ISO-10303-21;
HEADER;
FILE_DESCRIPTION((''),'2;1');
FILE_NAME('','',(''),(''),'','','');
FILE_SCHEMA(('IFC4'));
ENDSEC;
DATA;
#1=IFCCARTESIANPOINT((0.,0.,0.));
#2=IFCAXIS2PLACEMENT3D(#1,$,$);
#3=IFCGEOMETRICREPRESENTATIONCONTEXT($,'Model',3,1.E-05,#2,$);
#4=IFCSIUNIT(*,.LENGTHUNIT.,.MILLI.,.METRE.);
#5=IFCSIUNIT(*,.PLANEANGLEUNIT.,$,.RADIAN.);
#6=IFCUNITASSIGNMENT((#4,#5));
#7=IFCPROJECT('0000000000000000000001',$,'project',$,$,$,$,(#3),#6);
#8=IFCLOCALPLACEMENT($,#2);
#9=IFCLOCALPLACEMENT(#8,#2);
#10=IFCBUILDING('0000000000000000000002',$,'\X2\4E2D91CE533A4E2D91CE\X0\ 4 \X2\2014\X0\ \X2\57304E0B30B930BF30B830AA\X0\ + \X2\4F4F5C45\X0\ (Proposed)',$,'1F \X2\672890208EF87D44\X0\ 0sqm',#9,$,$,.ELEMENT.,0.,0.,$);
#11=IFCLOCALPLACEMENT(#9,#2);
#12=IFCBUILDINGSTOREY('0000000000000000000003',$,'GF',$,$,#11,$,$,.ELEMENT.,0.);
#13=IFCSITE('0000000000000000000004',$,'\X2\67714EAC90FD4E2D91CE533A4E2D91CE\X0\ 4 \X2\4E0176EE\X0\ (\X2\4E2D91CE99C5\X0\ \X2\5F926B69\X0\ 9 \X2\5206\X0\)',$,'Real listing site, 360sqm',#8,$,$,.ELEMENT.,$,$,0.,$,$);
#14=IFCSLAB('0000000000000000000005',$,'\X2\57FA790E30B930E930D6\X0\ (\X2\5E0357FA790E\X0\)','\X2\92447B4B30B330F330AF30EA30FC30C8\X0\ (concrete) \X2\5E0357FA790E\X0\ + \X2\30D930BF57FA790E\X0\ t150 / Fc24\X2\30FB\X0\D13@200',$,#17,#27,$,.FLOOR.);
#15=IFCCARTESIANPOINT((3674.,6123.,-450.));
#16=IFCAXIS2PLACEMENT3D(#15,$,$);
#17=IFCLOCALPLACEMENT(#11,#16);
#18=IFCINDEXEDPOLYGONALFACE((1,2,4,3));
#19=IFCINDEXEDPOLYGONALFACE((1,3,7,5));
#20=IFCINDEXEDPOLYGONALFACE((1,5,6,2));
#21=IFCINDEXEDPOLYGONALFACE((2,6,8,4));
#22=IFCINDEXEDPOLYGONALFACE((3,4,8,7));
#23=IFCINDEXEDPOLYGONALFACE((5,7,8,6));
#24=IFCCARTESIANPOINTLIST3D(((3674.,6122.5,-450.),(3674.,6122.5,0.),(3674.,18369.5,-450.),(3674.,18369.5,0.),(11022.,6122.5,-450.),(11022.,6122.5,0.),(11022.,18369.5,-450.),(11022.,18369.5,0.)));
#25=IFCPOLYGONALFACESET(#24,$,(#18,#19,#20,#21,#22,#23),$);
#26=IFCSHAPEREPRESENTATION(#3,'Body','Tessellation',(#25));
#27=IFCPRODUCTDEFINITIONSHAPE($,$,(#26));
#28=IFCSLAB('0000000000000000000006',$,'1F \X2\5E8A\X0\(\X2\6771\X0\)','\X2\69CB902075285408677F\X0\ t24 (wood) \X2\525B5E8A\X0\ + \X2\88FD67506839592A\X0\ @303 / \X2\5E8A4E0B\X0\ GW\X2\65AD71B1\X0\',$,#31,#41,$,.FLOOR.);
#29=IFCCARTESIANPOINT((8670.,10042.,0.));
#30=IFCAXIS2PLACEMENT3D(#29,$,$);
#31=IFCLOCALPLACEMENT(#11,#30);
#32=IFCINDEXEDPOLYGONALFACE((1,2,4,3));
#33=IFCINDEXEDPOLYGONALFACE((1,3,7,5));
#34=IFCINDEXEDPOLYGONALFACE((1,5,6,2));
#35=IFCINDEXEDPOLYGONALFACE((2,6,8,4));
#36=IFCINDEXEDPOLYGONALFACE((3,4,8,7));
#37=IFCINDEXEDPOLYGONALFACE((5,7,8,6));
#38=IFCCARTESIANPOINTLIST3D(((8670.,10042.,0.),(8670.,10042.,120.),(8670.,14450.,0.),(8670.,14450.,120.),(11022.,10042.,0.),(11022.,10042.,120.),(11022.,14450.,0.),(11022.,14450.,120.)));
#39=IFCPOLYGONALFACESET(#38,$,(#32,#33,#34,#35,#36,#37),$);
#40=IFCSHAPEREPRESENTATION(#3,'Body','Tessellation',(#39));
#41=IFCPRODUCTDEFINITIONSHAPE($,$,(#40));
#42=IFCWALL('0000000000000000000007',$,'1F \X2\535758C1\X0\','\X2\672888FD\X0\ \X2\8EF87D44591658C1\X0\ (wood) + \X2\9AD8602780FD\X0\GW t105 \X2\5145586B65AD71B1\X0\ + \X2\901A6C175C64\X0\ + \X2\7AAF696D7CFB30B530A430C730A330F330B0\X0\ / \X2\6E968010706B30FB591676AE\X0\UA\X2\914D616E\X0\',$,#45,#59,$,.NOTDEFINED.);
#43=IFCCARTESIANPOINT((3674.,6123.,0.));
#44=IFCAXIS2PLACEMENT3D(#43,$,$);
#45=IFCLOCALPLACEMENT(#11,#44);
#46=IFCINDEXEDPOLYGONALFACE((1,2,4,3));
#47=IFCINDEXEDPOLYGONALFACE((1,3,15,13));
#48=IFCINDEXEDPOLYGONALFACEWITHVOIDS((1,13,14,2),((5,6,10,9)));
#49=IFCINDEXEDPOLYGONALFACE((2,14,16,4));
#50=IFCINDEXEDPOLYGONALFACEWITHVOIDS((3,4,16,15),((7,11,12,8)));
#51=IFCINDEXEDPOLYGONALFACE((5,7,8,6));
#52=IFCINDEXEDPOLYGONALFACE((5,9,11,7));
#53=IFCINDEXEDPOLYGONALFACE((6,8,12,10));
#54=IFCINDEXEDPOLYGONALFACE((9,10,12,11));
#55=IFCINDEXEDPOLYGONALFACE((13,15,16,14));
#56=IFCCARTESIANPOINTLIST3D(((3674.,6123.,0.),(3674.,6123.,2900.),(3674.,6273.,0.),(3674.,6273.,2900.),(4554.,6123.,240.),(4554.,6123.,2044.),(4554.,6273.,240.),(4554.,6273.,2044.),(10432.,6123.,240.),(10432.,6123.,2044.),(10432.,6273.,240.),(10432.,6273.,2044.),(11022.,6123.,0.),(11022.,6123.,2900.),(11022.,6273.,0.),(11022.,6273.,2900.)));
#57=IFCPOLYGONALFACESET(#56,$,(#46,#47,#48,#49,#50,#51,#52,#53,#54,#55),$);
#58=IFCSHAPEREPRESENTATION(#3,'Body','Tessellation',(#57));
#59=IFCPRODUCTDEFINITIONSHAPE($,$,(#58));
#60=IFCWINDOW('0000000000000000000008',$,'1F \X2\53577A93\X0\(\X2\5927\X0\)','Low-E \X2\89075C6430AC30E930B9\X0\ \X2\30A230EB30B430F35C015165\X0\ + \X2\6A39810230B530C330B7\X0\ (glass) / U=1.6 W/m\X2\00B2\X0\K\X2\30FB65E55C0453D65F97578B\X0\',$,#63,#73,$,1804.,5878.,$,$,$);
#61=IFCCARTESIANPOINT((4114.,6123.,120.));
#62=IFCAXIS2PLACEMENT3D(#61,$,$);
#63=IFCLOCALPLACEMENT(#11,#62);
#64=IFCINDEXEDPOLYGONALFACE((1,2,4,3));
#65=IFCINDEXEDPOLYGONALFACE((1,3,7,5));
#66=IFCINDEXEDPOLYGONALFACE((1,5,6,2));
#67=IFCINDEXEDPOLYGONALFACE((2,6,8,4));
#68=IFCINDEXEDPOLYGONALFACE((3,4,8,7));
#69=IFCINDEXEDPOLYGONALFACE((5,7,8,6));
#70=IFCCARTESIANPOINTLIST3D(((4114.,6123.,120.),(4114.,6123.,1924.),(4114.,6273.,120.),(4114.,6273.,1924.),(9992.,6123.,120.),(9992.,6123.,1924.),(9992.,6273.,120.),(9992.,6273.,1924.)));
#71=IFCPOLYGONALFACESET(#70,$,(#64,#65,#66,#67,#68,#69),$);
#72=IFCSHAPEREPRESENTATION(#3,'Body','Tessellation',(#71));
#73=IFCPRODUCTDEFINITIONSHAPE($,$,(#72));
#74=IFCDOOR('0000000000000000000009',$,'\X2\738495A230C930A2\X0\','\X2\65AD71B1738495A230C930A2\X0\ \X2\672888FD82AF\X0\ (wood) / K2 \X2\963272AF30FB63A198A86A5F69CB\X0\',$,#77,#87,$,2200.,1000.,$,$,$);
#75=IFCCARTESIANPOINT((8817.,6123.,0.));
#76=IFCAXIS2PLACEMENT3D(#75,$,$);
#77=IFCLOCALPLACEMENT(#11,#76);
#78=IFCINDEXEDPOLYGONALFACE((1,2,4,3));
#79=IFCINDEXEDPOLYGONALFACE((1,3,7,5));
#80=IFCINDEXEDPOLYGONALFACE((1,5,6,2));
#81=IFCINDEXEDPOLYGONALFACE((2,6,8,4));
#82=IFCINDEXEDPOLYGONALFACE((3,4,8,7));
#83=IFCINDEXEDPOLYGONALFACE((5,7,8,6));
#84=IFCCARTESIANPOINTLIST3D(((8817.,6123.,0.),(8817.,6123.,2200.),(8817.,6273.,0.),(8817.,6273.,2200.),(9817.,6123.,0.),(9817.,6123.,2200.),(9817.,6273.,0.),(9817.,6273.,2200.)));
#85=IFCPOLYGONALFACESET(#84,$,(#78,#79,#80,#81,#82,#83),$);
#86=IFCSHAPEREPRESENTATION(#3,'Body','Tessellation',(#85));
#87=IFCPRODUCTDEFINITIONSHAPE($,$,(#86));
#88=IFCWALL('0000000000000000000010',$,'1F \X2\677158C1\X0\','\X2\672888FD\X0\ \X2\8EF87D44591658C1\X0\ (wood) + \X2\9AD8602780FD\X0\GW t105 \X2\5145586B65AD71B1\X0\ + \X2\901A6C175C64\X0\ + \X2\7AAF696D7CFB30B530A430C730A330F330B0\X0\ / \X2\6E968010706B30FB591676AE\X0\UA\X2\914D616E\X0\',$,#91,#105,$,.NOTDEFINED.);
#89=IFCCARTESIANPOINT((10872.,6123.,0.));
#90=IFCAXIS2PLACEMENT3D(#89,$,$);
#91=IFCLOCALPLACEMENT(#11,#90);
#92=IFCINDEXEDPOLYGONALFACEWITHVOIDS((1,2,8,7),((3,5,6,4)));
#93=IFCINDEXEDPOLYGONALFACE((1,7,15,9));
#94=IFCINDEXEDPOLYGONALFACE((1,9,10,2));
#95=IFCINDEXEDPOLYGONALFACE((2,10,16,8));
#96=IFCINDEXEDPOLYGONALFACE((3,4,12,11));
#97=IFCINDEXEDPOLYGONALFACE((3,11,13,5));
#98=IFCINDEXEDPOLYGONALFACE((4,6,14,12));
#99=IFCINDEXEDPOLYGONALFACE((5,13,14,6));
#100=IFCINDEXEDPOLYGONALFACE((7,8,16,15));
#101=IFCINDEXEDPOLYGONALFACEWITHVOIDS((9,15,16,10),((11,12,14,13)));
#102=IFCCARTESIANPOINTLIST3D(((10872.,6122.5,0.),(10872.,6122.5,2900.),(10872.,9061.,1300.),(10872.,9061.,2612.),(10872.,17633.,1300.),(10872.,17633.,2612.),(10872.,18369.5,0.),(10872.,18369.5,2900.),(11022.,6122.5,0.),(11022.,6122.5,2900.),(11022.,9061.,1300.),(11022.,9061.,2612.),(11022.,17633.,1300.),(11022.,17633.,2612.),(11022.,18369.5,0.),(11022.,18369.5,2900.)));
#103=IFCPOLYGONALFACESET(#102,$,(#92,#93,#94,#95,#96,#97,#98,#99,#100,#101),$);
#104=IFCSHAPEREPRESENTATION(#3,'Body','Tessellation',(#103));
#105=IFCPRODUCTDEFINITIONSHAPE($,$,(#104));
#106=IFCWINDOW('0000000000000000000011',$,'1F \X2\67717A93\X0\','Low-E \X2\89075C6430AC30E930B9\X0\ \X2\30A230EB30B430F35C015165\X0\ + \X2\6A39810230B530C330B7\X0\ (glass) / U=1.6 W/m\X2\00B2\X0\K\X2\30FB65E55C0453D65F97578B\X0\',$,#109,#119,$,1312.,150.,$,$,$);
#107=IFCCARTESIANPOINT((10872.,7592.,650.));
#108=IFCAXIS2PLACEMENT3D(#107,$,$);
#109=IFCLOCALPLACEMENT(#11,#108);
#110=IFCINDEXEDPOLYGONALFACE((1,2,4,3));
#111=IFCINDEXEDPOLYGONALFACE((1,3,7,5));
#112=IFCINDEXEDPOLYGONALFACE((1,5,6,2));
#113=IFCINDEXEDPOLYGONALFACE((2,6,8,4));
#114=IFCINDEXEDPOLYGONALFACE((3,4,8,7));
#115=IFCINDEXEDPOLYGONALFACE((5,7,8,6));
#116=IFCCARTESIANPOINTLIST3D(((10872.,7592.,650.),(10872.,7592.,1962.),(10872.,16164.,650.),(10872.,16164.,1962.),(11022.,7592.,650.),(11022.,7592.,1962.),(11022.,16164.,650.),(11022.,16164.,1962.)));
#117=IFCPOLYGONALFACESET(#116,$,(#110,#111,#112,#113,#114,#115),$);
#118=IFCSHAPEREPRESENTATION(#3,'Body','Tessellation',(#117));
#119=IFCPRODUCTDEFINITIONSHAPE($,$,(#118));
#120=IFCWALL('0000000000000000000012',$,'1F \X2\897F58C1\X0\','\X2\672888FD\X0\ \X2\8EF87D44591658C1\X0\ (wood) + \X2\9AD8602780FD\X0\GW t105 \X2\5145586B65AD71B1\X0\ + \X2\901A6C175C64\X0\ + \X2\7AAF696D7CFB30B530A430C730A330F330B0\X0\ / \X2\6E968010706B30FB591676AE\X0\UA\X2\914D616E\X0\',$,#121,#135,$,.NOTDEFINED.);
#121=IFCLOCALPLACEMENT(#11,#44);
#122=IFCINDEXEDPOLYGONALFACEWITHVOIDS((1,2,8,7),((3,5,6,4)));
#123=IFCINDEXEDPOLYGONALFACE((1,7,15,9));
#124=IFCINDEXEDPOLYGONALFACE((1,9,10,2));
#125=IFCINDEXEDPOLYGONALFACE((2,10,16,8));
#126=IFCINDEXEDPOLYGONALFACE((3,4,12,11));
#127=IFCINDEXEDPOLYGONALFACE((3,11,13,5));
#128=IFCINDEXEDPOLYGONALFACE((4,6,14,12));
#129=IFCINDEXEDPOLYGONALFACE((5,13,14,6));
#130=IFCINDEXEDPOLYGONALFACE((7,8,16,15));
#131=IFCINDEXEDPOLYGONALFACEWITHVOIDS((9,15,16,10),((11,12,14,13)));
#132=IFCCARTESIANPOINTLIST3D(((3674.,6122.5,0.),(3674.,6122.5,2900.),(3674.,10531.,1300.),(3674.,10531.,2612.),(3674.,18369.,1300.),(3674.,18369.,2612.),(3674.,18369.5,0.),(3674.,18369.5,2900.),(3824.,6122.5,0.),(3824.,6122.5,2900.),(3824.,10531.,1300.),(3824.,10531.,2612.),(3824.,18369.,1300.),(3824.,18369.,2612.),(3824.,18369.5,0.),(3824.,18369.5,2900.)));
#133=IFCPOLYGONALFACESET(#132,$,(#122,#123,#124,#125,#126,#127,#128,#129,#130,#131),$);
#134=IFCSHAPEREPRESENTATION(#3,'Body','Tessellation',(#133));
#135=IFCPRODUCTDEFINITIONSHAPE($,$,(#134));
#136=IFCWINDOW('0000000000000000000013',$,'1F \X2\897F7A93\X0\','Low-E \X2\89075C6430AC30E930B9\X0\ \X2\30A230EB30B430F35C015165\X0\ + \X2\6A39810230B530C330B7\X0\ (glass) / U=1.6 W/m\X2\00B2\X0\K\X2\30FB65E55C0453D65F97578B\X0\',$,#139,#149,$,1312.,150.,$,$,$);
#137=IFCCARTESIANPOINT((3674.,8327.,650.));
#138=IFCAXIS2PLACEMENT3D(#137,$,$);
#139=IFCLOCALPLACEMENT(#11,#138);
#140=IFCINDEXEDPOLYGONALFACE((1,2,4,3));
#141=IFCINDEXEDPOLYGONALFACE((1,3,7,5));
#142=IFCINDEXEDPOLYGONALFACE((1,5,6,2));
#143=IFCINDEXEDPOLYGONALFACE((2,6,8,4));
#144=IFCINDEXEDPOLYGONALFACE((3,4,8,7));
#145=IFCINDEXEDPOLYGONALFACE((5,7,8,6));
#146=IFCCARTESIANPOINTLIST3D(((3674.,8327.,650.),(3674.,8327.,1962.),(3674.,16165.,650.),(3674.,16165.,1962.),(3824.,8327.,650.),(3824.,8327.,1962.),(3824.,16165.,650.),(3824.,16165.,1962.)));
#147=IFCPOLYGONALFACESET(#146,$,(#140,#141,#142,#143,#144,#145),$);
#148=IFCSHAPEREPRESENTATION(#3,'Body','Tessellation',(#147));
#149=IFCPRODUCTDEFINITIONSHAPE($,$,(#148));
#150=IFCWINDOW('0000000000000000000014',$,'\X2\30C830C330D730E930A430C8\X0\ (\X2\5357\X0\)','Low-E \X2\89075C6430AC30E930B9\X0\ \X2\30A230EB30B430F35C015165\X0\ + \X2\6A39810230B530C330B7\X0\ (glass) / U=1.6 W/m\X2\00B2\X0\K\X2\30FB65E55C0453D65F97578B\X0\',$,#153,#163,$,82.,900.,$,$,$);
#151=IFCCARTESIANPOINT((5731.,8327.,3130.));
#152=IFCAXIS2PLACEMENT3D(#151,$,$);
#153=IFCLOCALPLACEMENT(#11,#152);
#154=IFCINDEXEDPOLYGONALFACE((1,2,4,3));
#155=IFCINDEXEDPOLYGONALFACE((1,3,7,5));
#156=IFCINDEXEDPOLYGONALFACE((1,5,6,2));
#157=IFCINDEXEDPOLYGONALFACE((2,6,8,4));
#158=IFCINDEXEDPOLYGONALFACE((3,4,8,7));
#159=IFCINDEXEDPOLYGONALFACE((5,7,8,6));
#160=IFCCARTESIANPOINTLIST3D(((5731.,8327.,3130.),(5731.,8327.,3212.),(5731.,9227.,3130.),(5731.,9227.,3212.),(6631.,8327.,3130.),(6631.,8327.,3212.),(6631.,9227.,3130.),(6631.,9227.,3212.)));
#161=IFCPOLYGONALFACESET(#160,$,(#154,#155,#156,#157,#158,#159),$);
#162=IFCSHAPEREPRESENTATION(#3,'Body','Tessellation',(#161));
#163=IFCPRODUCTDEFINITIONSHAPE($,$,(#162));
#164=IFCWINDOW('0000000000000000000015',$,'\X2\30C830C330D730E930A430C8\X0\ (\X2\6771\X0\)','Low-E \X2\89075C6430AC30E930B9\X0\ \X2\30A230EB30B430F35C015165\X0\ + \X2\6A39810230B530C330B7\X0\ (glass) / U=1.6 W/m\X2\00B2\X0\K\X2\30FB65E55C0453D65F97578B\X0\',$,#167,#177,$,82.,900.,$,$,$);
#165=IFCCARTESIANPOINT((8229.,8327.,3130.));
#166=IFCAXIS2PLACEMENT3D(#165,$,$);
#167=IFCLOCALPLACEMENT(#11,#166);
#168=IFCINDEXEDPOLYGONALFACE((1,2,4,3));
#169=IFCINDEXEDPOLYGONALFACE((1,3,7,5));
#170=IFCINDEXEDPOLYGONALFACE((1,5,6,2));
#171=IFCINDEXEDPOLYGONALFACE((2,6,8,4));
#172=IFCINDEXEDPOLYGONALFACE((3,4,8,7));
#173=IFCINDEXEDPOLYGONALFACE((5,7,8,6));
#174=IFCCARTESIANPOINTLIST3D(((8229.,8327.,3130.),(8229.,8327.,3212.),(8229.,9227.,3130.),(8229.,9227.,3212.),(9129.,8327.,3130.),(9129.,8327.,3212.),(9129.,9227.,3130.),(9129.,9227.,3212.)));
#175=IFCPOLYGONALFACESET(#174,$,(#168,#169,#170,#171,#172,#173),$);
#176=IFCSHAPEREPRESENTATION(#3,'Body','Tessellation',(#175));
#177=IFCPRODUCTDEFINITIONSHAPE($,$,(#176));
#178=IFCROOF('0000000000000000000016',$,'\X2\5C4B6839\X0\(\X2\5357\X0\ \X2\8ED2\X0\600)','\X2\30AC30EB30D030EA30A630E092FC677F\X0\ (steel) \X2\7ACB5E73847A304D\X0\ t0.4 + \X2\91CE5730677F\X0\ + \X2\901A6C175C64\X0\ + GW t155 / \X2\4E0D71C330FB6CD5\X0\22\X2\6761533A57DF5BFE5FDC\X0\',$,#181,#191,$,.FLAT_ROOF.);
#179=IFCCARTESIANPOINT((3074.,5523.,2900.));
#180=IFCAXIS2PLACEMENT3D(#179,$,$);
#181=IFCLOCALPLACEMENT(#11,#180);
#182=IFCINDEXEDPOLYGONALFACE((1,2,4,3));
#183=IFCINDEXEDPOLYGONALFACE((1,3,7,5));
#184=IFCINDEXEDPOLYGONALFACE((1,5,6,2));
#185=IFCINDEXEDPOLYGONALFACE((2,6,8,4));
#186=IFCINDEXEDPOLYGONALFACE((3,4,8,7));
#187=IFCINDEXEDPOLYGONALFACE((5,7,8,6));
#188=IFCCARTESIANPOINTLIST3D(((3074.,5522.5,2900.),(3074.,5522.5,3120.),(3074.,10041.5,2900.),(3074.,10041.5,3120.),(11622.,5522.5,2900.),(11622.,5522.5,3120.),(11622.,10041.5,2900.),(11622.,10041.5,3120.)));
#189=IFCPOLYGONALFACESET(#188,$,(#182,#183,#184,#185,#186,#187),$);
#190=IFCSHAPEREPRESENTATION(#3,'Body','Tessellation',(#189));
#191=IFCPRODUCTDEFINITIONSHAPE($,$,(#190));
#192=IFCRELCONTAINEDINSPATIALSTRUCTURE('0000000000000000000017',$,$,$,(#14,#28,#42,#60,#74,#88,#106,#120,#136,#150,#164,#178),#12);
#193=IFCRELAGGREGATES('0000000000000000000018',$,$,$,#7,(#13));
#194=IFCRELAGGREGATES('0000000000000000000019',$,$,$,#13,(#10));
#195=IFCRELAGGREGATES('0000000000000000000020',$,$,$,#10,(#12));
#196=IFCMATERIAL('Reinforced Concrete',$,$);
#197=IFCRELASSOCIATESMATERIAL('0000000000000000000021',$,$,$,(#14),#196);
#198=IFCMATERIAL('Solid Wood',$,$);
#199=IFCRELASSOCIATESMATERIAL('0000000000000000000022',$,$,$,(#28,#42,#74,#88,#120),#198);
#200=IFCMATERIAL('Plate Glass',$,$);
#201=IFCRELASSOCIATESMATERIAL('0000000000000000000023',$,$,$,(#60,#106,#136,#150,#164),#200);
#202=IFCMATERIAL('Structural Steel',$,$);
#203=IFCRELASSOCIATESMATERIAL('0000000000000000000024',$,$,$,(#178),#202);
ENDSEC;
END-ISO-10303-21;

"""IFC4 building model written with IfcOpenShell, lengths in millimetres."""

from ifc_helpers import new_model, si_unit, frame, frame_2d, origin, place, context, project, spatial, rectangle, extrude, material, element, fill, save


model = new_model("IFC4")

# Units and contexts
model_context = context("Model", 3, precision=1e-05, world=origin())
ifc_project = project(units=[si_unit("LENGTHUNIT", "METRE", prefix="MILLI"), si_unit("PLANEANGLEUNIT", "RADIAN")], contexts=[model_context])

# Site, building, storey
site_placement = place(None, origin())
site = spatial("IfcSite", under=ifc_project, at=site_placement, Name="東京都中野区中野 4 丁目 (中野駅 徒歩 9 分)", ObjectType="Real listing site, 360sqm", CompositionType="ELEMENT", RefElevation=0.0)
building_placement = place(site_placement, origin())
building = spatial("IfcBuilding", under=site, at=building_placement, Name="中野区中野 4 — 地下スタジオ + 住居 (Proposed)", ObjectType="1F 木造軸組 0sqm", CompositionType="ELEMENT", ElevationOfRefHeight=0.0, ElevationOfTerrain=0.0)
storey_placement = place(building_placement, origin())
storey = spatial("IfcBuildingStorey", under=building, at=storey_placement, Name="GF", CompositionType="ELEMENT", Elevation=0.0)

# Slabs
ifc_material_1 = material(Name="Reinforced Concrete")
slab_1_placement = place(storey_placement, frame((3674.0, 6123.0, -450.0)))
element("IfcSlab", 1, at=slab_1_placement, inside=storey, material=ifc_material_1, Name="基礎スラブ (布基礎)", Description="鉄筋コンクリート (concrete) 布基礎 + ベタ基礎 t150 / Fc24・D13@200", PredefinedType="FLOOR", context=model_context, shape_type="SweptSolid", body=[
    extrude(rectangle(XDim=7348.0, YDim=12247.0, at=frame_2d((3674.0, 6123.0))), frame((3674.0, 6123.0, -450.0)), (0.0, 0.0, 1.0), 450.0),
])
ifc_material_2 = material(Name="Solid Wood")
slab_2_placement = place(storey_placement, frame((8670.0, 10042.0, 0.0)))
element("IfcSlab", 2, at=slab_2_placement, inside=storey, material=ifc_material_2, Name="1F 床(東)", Description="構造用合板 t24 (wood) 剛床 + 製材根太 @303 / 床下 GW断熱", PredefinedType="FLOOR", context=model_context, shape_type="SweptSolid", body=[
    extrude(rectangle(XDim=2352.0, YDim=4408.0, at=frame_2d((1176.0, 2204.0))), frame((8670.0, 10042.0, 0.0)), (0.0, 0.0, 1.0), 120.0),
])

# Wall, openings, window, door
wall_1_placement = place(storey_placement, frame((3674.0, 6123.0, 0.0)))
wall_1 = element("IfcWall", 3, at=wall_1_placement, inside=storey, material=ifc_material_2, Name="1F 南壁", Description="木製 軸組外壁 (wood) + 高性能GW t105 充填断熱 + 通気層 + 窯業系サイディング / 準耐火・外皮UA配慮", PredefinedType="NOTDEFINED", context=model_context, shape_type="SweptSolid", body=[
    extrude(rectangle(XDim=7348.0, YDim=150.0, at=frame_2d((3674.0, 75.0))), frame((3674.0, 6123.0, 0.0)), (0.0, 0.0, 1.0), 2900.0),
])
opening_1_placement = place(storey_placement, frame((4114.0, 6123.0, 120.0)))
opening_1 = element("IfcOpeningElement", 4, at=opening_1_placement, cuts=wall_1, PredefinedType="NOTDEFINED", context=model_context, shape_type="SweptSolid", body=[
    extrude(rectangle(XDim=5878.0, YDim=150.0, at=frame_2d((2939.0, 75.0))), frame((4114.0, 6123.0, 120.0)), (0.0, 0.0, 1.0), 1804.0),
])
opening_2_placement = place(storey_placement, frame((8817.0, 6123.0, 0.0)))
opening_2 = element("IfcOpeningElement", 5, at=opening_2_placement, cuts=wall_1, PredefinedType="NOTDEFINED", context=model_context, shape_type="SweptSolid", body=[
    extrude(rectangle(XDim=1000.0, YDim=150.0, at=frame_2d((500.0, 75.0))), frame((8817.0, 6123.0, 0.0)), (0.0, 0.0, 1.0), 2200.0),
])
ifc_material_3 = material(Name="Plate Glass")
window_1_placement = place(storey_placement, frame((4114.0, 6123.0, 120.0)))
window_1 = element("IfcWindow", 6, at=window_1_placement, inside=storey, material=ifc_material_3, Name="1F 南窓(大)", Description="Low-E 複層ガラス アルゴン封入 + 樹脂サッシ (glass) / U=1.6 W/m²K・日射取得型", OverallHeight=1804.0, OverallWidth=5878.0, context=model_context, shape_type="SweptSolid", body=[
    extrude(rectangle(XDim=5878.0, YDim=150.0, at=frame_2d((2939.0, 75.0))), frame((4114.0, 6123.0, 120.0)), (0.0, 0.0, 1.0), 1804.0),
])
fill(opening_1, window_1)
door_placement = place(storey_placement, frame((8817.0, 6123.0, 0.0)))
door = element("IfcDoor", 7, at=door_placement, inside=storey, material=ifc_material_2, Name="玄関ドア", Description="断熱玄関ドア 木製芯 (wood) / K2 防犯・採風機構", OverallHeight=2200.0, OverallWidth=1000.0, context=model_context, shape_type="SweptSolid", body=[
    extrude(rectangle(XDim=1000.0, YDim=150.0, at=frame_2d((500.0, 75.0))), frame((8817.0, 6123.0, 0.0)), (0.0, 0.0, 1.0), 2200.0),
])
fill(opening_2, door)

# Walls, openings, windows
wall_2_placement = place(storey_placement, frame((10872.0, 6123.0, 0.0)))
wall_2 = element("IfcWall", 8, at=wall_2_placement, inside=storey, material=ifc_material_2, Name="1F 東壁", Description="木製 軸組外壁 (wood) + 高性能GW t105 充填断熱 + 通気層 + 窯業系サイディング / 準耐火・外皮UA配慮", PredefinedType="NOTDEFINED", context=model_context, shape_type="SweptSolid", body=[
    extrude(rectangle(XDim=150.0, YDim=12247.0, at=frame_2d((75.0, 6123.0))), frame((10872.0, 6123.0, 0.0)), (0.0, 0.0, 1.0), 2900.0),
])
opening_3_placement = place(storey_placement, frame((10872.0, 7592.0, 650.0)))
opening_3 = element("IfcOpeningElement", 9, at=opening_3_placement, cuts=wall_2, PredefinedType="NOTDEFINED", context=model_context, shape_type="SweptSolid", body=[
    extrude(rectangle(XDim=150.0, YDim=8572.0, at=frame_2d((75.0, 4286.0))), frame((10872.0, 7592.0, 650.0)), (0.0, 0.0, 1.0), 1312.0),
])
window_2_placement = place(storey_placement, frame((10872.0, 7592.0, 650.0)))
window_2 = element("IfcWindow", 10, at=window_2_placement, inside=storey, material=ifc_material_3, Name="1F 東窓", Description="Low-E 複層ガラス アルゴン封入 + 樹脂サッシ (glass) / U=1.6 W/m²K・日射取得型", OverallHeight=1312.0, OverallWidth=150.0, context=model_context, shape_type="SweptSolid", body=[
    extrude(rectangle(XDim=150.0, YDim=8572.0, at=frame_2d((75.0, 4286.0))), frame((10872.0, 7592.0, 650.0)), (0.0, 0.0, 1.0), 1312.0),
])
fill(opening_3, window_2)
wall_3_placement = place(storey_placement, frame((3674.0, 6123.0, 0.0)))
wall_3 = element("IfcWall", 11, at=wall_3_placement, inside=storey, material=ifc_material_2, Name="1F 西壁", Description="木製 軸組外壁 (wood) + 高性能GW t105 充填断熱 + 通気層 + 窯業系サイディング / 準耐火・外皮UA配慮", PredefinedType="NOTDEFINED", context=model_context, shape_type="SweptSolid", body=[
    extrude(rectangle(XDim=150.0, YDim=12247.0, at=frame_2d((75.0, 6123.0))), frame((3674.0, 6123.0, 0.0)), (0.0, 0.0, 1.0), 2900.0),
])
opening_4_placement = place(storey_placement, frame((3674.0, 8327.0, 650.0)))
opening_4 = element("IfcOpeningElement", 12, at=opening_4_placement, cuts=wall_3, PredefinedType="NOTDEFINED", context=model_context, shape_type="SweptSolid", body=[
    extrude(rectangle(XDim=150.0, YDim=7838.0, at=frame_2d((75.0, 3919.0))), frame((3674.0, 8327.0, 650.0)), (0.0, 0.0, 1.0), 1312.0),
])
window_3_placement = place(storey_placement, frame((3674.0, 8327.0, 650.0)))
window_3 = element("IfcWindow", 13, at=window_3_placement, inside=storey, material=ifc_material_3, Name="1F 西窓", Description="Low-E 複層ガラス アルゴン封入 + 樹脂サッシ (glass) / U=1.6 W/m²K・日射取得型", OverallHeight=1312.0, OverallWidth=150.0, context=model_context, shape_type="SweptSolid", body=[
    extrude(rectangle(XDim=150.0, YDim=7838.0, at=frame_2d((75.0, 3919.0))), frame((3674.0, 8327.0, 650.0)), (0.0, 0.0, 1.0), 1312.0),
])
fill(opening_4, window_3)

# Windows
window_4_placement = place(storey_placement, frame((5731.0, 8327.0, 3130.0)))
element("IfcWindow", 14, at=window_4_placement, inside=storey, material=ifc_material_3, Name="トップライト (南)", Description="Low-E 複層ガラス アルゴン封入 + 樹脂サッシ (glass) / U=1.6 W/m²K・日射取得型", OverallHeight=82.0, OverallWidth=900.0, context=model_context, shape_type="SweptSolid", body=[
    extrude(rectangle(XDim=900.0, YDim=900.0, at=frame_2d((450.0, 450.0))), frame((5731.0, 8327.0, 3130.0)), (0.0, 0.0, 1.0), 82.0),
])
window_5_placement = place(storey_placement, frame((8229.0, 8327.0, 3130.0)))
element("IfcWindow", 15, at=window_5_placement, inside=storey, material=ifc_material_3, Name="トップライト (東)", Description="Low-E 複層ガラス アルゴン封入 + 樹脂サッシ (glass) / U=1.6 W/m²K・日射取得型", OverallHeight=82.0, OverallWidth=900.0, context=model_context, shape_type="SweptSolid", body=[
    extrude(rectangle(XDim=900.0, YDim=900.0, at=frame_2d((450.0, 450.0))), frame((8229.0, 8327.0, 3130.0)), (0.0, 0.0, 1.0), 82.0),
])

# Roof
ifc_material_4 = material(Name="Structural Steel")
roof_placement = place(storey_placement, frame((3074.0, 5523.0, 2900.0)))
element("IfcRoof", 16, at=roof_placement, inside=storey, material=ifc_material_4, Name="屋根(南 軒600)", Description="ガルバリウム鋼板 (steel) 立平葺き t0.4 + 野地板 + 通気層 + GW t155 / 不燃・法22条区域対応", PredefinedType="FLAT_ROOF", context=model_context, shape_type="SweptSolid", body=[
    extrude(rectangle(XDim=8548.0, YDim=4519.0, at=frame_2d((4274.0, 2259.0))), frame((3074.0, 5523.0, 2900.0)), (0.0, 0.0, 1.0), 220.0),
])

save(model, "model.ifc")
